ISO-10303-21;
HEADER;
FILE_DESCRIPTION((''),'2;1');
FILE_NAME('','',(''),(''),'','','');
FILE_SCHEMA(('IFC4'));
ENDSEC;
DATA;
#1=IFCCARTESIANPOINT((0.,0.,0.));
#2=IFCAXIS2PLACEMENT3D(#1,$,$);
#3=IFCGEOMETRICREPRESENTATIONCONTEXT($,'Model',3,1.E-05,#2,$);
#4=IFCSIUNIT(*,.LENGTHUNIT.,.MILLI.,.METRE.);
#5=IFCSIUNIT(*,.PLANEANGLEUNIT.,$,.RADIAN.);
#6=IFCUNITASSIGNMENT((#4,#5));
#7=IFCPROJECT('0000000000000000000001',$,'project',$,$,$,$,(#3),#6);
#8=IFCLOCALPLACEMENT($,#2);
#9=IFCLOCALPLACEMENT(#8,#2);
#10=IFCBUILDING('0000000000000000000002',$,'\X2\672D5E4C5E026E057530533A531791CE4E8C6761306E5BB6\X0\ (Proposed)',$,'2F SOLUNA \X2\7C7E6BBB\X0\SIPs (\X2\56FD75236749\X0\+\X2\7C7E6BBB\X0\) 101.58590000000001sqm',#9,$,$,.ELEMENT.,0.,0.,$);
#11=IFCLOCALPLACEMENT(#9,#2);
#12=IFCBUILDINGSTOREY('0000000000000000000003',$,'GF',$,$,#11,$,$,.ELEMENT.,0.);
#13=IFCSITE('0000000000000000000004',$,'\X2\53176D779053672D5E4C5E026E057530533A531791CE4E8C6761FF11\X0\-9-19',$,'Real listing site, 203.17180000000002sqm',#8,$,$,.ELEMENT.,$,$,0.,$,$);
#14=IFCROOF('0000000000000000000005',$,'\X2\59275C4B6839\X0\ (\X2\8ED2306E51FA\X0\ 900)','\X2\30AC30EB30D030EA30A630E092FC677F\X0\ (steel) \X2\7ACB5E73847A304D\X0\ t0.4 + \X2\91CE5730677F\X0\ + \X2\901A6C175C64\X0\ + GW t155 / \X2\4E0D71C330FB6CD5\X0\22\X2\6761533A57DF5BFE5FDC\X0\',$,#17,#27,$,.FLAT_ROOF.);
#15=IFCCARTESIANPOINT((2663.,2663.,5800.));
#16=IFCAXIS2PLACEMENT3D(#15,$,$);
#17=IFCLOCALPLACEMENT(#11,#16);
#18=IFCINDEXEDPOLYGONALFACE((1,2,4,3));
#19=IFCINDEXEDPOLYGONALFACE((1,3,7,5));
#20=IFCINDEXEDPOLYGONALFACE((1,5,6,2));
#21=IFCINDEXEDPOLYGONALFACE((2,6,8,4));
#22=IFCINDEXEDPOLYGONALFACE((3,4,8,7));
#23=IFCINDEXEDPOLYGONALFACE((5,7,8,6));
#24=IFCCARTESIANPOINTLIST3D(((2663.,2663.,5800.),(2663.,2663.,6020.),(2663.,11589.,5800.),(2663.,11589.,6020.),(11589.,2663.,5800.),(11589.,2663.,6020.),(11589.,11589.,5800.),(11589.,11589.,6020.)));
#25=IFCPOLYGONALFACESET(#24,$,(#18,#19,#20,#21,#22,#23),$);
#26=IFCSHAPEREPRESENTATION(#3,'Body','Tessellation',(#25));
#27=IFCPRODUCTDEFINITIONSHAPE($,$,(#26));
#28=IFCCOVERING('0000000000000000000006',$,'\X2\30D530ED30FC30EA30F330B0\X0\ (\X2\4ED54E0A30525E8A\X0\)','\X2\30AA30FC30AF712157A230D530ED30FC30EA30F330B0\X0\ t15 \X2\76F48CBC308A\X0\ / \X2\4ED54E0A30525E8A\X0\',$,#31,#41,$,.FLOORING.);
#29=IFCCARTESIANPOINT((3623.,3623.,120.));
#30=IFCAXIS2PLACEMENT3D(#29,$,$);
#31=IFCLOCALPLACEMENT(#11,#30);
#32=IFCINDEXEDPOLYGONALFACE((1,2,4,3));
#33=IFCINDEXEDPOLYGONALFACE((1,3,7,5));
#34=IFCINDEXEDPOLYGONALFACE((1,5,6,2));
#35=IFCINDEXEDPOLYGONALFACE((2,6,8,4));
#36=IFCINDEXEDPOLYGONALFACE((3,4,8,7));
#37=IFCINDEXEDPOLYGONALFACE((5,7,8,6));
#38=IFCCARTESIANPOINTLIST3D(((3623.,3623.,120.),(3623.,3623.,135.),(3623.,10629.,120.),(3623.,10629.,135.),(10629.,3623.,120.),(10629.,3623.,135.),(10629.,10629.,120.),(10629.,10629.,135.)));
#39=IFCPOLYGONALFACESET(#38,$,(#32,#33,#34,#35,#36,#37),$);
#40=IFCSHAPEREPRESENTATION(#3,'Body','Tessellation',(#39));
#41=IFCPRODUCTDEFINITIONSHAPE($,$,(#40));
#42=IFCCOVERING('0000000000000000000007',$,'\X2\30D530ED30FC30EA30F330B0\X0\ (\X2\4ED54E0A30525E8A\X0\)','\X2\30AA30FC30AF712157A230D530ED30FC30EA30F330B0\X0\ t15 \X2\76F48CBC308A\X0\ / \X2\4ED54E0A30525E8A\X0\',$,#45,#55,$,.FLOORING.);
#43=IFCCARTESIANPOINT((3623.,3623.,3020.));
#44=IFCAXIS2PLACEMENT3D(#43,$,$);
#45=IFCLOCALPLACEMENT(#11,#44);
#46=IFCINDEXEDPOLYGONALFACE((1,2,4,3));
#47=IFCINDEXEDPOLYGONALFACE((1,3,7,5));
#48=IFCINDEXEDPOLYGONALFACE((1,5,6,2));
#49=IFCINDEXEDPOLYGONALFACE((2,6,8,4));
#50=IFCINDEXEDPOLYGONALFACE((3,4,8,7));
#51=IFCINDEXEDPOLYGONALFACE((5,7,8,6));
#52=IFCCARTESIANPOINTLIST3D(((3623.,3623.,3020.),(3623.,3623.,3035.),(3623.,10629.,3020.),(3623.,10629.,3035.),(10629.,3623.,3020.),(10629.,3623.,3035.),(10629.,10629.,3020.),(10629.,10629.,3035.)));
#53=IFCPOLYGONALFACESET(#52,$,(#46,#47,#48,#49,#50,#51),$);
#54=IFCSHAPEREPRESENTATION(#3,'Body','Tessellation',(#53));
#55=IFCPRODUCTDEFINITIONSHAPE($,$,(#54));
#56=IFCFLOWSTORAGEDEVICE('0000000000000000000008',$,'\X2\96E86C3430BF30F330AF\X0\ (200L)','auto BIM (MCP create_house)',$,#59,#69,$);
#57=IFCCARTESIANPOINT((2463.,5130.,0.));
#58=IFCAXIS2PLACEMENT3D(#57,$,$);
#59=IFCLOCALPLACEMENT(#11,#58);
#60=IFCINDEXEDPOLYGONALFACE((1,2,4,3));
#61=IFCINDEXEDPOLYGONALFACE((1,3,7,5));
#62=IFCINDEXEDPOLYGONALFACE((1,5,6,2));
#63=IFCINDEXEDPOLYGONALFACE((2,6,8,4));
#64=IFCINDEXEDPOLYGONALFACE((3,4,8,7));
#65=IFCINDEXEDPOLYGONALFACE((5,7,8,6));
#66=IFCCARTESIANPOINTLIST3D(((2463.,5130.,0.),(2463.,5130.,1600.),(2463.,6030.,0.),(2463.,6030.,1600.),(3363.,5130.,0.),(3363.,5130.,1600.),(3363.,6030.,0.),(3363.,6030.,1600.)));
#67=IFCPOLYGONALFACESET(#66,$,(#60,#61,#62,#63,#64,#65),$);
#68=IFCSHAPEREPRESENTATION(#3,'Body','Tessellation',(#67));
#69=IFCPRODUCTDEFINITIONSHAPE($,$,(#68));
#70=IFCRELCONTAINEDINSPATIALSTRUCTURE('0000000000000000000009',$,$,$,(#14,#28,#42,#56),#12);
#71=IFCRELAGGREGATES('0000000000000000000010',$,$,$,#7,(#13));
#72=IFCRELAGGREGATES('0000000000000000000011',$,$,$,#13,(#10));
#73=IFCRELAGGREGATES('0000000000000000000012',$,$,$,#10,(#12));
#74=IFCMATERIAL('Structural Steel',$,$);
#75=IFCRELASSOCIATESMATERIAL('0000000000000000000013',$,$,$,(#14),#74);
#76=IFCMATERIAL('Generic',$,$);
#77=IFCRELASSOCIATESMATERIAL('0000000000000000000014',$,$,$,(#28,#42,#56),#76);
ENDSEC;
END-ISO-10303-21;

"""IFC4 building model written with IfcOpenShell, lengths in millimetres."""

from ifc_helpers import new_model, si_unit, frame, frame_2d, origin, place, context, project, spatial, rectangle, extrude, material, element, save


model = new_model("IFC4")

# Units and contexts
model_context = context("Model", 3, precision=1e-05, world=origin())
ifc_project = project(units=[si_unit("LENGTHUNIT", "METRE", prefix="MILLI"), si_unit("PLANEANGLEUNIT", "RADIAN")], contexts=[model_context])

# Site, building, storey
site_placement = place(None, origin())
site = spatial("IfcSite", under=ifc_project, at=site_placement, Name="北海道札幌市清田区北野二条１-9-19", ObjectType="Real listing site, 203.17180000000002sqm", CompositionType="ELEMENT", RefElevation=0.0)
building_placement = place(site_placement, origin())
building = spatial("IfcBuilding", under=site, at=building_placement, Name="札幌市清田区北野二条の家 (Proposed)", ObjectType="2F SOLUNA 籾殻SIPs (国産杉+籾殻) 101.58590000000001sqm", CompositionType="ELEMENT", ElevationOfRefHeight=0.0, ElevationOfTerrain=0.0)
storey_placement = place(building_placement, origin())
storey = spatial("IfcBuildingStorey", under=building, at=storey_placement, Name="GF", CompositionType="ELEMENT", Elevation=0.0)

# Roof
ifc_material_1 = material(Name="Structural Steel")
roof_placement = place(storey_placement, frame((2663.0, 2663.0, 5800.0)))
element("IfcRoof", 1, at=roof_placement, inside=storey, material=ifc_material_1, Name="大屋根 (軒の出 900)", Description="ガルバリウム鋼板 (steel) 立平葺き t0.4 + 野地板 + 通気層 + GW t155 / 不燃・法22条区域対応", PredefinedType="FLAT_ROOF", context=model_context, shape_type="SweptSolid", body=[
    extrude(rectangle(XDim=8926.0, YDim=8926.0, at=frame_2d((4463.0, 4463.0))), frame((2663.0, 2663.0, 5800.0)), (0.0, 0.0, 1.0), 220.0),
])

# Coverings
ifc_material_2 = material(Name="Generic")
covering_1_placement = place(storey_placement, frame((3623.0, 3623.0, 120.0)))
element("IfcCovering", 2, at=covering_1_placement, inside=storey, material=ifc_material_2, Name="フローリング (仕上げ床)", Description="オーク無垢フローリング t15 直貼り / 仕上げ床", PredefinedType="FLOORING", context=model_context, shape_type="SweptSolid", body=[
    extrude(rectangle(XDim=7006.0, YDim=7006.0, at=frame_2d((3503.0, 3503.0))), frame((3623.0, 3623.0, 120.0)), (0.0, 0.0, 1.0), 15.0),
])
covering_2_placement = place(storey_placement, frame((3623.0, 3623.0, 3020.0)))
element("IfcCovering", 3, at=covering_2_placement, inside=storey, material=ifc_material_2, Name="フローリング (仕上げ床)", Description="オーク無垢フローリング t15 直貼り / 仕上げ床", PredefinedType="FLOORING", context=model_context, shape_type="SweptSolid", body=[
    extrude(rectangle(XDim=7006.0, YDim=7006.0, at=frame_2d((3503.0, 3503.0))), frame((3623.0, 3623.0, 3020.0)), (0.0, 0.0, 1.0), 15.0),
])

# Flow storage device
flow_storage_device_placement = place(storey_placement, frame((2463.0, 5130.0, 0.0)))
element("IfcFlowStorageDevice", 4, at=flow_storage_device_placement, inside=storey, material=ifc_material_2, Name="雨水タンク (200L)", Description="auto BIM (MCP create_house)", context=model_context, shape_type="SweptSolid", body=[
    extrude(rectangle(XDim=900.0, YDim=900.0, at=frame_2d((450.0, 450.0))), frame((2463.0, 5130.0, 0.0)), (0.0, 0.0, 1.0), 1600.0),
])

save(model, "model.ifc")
